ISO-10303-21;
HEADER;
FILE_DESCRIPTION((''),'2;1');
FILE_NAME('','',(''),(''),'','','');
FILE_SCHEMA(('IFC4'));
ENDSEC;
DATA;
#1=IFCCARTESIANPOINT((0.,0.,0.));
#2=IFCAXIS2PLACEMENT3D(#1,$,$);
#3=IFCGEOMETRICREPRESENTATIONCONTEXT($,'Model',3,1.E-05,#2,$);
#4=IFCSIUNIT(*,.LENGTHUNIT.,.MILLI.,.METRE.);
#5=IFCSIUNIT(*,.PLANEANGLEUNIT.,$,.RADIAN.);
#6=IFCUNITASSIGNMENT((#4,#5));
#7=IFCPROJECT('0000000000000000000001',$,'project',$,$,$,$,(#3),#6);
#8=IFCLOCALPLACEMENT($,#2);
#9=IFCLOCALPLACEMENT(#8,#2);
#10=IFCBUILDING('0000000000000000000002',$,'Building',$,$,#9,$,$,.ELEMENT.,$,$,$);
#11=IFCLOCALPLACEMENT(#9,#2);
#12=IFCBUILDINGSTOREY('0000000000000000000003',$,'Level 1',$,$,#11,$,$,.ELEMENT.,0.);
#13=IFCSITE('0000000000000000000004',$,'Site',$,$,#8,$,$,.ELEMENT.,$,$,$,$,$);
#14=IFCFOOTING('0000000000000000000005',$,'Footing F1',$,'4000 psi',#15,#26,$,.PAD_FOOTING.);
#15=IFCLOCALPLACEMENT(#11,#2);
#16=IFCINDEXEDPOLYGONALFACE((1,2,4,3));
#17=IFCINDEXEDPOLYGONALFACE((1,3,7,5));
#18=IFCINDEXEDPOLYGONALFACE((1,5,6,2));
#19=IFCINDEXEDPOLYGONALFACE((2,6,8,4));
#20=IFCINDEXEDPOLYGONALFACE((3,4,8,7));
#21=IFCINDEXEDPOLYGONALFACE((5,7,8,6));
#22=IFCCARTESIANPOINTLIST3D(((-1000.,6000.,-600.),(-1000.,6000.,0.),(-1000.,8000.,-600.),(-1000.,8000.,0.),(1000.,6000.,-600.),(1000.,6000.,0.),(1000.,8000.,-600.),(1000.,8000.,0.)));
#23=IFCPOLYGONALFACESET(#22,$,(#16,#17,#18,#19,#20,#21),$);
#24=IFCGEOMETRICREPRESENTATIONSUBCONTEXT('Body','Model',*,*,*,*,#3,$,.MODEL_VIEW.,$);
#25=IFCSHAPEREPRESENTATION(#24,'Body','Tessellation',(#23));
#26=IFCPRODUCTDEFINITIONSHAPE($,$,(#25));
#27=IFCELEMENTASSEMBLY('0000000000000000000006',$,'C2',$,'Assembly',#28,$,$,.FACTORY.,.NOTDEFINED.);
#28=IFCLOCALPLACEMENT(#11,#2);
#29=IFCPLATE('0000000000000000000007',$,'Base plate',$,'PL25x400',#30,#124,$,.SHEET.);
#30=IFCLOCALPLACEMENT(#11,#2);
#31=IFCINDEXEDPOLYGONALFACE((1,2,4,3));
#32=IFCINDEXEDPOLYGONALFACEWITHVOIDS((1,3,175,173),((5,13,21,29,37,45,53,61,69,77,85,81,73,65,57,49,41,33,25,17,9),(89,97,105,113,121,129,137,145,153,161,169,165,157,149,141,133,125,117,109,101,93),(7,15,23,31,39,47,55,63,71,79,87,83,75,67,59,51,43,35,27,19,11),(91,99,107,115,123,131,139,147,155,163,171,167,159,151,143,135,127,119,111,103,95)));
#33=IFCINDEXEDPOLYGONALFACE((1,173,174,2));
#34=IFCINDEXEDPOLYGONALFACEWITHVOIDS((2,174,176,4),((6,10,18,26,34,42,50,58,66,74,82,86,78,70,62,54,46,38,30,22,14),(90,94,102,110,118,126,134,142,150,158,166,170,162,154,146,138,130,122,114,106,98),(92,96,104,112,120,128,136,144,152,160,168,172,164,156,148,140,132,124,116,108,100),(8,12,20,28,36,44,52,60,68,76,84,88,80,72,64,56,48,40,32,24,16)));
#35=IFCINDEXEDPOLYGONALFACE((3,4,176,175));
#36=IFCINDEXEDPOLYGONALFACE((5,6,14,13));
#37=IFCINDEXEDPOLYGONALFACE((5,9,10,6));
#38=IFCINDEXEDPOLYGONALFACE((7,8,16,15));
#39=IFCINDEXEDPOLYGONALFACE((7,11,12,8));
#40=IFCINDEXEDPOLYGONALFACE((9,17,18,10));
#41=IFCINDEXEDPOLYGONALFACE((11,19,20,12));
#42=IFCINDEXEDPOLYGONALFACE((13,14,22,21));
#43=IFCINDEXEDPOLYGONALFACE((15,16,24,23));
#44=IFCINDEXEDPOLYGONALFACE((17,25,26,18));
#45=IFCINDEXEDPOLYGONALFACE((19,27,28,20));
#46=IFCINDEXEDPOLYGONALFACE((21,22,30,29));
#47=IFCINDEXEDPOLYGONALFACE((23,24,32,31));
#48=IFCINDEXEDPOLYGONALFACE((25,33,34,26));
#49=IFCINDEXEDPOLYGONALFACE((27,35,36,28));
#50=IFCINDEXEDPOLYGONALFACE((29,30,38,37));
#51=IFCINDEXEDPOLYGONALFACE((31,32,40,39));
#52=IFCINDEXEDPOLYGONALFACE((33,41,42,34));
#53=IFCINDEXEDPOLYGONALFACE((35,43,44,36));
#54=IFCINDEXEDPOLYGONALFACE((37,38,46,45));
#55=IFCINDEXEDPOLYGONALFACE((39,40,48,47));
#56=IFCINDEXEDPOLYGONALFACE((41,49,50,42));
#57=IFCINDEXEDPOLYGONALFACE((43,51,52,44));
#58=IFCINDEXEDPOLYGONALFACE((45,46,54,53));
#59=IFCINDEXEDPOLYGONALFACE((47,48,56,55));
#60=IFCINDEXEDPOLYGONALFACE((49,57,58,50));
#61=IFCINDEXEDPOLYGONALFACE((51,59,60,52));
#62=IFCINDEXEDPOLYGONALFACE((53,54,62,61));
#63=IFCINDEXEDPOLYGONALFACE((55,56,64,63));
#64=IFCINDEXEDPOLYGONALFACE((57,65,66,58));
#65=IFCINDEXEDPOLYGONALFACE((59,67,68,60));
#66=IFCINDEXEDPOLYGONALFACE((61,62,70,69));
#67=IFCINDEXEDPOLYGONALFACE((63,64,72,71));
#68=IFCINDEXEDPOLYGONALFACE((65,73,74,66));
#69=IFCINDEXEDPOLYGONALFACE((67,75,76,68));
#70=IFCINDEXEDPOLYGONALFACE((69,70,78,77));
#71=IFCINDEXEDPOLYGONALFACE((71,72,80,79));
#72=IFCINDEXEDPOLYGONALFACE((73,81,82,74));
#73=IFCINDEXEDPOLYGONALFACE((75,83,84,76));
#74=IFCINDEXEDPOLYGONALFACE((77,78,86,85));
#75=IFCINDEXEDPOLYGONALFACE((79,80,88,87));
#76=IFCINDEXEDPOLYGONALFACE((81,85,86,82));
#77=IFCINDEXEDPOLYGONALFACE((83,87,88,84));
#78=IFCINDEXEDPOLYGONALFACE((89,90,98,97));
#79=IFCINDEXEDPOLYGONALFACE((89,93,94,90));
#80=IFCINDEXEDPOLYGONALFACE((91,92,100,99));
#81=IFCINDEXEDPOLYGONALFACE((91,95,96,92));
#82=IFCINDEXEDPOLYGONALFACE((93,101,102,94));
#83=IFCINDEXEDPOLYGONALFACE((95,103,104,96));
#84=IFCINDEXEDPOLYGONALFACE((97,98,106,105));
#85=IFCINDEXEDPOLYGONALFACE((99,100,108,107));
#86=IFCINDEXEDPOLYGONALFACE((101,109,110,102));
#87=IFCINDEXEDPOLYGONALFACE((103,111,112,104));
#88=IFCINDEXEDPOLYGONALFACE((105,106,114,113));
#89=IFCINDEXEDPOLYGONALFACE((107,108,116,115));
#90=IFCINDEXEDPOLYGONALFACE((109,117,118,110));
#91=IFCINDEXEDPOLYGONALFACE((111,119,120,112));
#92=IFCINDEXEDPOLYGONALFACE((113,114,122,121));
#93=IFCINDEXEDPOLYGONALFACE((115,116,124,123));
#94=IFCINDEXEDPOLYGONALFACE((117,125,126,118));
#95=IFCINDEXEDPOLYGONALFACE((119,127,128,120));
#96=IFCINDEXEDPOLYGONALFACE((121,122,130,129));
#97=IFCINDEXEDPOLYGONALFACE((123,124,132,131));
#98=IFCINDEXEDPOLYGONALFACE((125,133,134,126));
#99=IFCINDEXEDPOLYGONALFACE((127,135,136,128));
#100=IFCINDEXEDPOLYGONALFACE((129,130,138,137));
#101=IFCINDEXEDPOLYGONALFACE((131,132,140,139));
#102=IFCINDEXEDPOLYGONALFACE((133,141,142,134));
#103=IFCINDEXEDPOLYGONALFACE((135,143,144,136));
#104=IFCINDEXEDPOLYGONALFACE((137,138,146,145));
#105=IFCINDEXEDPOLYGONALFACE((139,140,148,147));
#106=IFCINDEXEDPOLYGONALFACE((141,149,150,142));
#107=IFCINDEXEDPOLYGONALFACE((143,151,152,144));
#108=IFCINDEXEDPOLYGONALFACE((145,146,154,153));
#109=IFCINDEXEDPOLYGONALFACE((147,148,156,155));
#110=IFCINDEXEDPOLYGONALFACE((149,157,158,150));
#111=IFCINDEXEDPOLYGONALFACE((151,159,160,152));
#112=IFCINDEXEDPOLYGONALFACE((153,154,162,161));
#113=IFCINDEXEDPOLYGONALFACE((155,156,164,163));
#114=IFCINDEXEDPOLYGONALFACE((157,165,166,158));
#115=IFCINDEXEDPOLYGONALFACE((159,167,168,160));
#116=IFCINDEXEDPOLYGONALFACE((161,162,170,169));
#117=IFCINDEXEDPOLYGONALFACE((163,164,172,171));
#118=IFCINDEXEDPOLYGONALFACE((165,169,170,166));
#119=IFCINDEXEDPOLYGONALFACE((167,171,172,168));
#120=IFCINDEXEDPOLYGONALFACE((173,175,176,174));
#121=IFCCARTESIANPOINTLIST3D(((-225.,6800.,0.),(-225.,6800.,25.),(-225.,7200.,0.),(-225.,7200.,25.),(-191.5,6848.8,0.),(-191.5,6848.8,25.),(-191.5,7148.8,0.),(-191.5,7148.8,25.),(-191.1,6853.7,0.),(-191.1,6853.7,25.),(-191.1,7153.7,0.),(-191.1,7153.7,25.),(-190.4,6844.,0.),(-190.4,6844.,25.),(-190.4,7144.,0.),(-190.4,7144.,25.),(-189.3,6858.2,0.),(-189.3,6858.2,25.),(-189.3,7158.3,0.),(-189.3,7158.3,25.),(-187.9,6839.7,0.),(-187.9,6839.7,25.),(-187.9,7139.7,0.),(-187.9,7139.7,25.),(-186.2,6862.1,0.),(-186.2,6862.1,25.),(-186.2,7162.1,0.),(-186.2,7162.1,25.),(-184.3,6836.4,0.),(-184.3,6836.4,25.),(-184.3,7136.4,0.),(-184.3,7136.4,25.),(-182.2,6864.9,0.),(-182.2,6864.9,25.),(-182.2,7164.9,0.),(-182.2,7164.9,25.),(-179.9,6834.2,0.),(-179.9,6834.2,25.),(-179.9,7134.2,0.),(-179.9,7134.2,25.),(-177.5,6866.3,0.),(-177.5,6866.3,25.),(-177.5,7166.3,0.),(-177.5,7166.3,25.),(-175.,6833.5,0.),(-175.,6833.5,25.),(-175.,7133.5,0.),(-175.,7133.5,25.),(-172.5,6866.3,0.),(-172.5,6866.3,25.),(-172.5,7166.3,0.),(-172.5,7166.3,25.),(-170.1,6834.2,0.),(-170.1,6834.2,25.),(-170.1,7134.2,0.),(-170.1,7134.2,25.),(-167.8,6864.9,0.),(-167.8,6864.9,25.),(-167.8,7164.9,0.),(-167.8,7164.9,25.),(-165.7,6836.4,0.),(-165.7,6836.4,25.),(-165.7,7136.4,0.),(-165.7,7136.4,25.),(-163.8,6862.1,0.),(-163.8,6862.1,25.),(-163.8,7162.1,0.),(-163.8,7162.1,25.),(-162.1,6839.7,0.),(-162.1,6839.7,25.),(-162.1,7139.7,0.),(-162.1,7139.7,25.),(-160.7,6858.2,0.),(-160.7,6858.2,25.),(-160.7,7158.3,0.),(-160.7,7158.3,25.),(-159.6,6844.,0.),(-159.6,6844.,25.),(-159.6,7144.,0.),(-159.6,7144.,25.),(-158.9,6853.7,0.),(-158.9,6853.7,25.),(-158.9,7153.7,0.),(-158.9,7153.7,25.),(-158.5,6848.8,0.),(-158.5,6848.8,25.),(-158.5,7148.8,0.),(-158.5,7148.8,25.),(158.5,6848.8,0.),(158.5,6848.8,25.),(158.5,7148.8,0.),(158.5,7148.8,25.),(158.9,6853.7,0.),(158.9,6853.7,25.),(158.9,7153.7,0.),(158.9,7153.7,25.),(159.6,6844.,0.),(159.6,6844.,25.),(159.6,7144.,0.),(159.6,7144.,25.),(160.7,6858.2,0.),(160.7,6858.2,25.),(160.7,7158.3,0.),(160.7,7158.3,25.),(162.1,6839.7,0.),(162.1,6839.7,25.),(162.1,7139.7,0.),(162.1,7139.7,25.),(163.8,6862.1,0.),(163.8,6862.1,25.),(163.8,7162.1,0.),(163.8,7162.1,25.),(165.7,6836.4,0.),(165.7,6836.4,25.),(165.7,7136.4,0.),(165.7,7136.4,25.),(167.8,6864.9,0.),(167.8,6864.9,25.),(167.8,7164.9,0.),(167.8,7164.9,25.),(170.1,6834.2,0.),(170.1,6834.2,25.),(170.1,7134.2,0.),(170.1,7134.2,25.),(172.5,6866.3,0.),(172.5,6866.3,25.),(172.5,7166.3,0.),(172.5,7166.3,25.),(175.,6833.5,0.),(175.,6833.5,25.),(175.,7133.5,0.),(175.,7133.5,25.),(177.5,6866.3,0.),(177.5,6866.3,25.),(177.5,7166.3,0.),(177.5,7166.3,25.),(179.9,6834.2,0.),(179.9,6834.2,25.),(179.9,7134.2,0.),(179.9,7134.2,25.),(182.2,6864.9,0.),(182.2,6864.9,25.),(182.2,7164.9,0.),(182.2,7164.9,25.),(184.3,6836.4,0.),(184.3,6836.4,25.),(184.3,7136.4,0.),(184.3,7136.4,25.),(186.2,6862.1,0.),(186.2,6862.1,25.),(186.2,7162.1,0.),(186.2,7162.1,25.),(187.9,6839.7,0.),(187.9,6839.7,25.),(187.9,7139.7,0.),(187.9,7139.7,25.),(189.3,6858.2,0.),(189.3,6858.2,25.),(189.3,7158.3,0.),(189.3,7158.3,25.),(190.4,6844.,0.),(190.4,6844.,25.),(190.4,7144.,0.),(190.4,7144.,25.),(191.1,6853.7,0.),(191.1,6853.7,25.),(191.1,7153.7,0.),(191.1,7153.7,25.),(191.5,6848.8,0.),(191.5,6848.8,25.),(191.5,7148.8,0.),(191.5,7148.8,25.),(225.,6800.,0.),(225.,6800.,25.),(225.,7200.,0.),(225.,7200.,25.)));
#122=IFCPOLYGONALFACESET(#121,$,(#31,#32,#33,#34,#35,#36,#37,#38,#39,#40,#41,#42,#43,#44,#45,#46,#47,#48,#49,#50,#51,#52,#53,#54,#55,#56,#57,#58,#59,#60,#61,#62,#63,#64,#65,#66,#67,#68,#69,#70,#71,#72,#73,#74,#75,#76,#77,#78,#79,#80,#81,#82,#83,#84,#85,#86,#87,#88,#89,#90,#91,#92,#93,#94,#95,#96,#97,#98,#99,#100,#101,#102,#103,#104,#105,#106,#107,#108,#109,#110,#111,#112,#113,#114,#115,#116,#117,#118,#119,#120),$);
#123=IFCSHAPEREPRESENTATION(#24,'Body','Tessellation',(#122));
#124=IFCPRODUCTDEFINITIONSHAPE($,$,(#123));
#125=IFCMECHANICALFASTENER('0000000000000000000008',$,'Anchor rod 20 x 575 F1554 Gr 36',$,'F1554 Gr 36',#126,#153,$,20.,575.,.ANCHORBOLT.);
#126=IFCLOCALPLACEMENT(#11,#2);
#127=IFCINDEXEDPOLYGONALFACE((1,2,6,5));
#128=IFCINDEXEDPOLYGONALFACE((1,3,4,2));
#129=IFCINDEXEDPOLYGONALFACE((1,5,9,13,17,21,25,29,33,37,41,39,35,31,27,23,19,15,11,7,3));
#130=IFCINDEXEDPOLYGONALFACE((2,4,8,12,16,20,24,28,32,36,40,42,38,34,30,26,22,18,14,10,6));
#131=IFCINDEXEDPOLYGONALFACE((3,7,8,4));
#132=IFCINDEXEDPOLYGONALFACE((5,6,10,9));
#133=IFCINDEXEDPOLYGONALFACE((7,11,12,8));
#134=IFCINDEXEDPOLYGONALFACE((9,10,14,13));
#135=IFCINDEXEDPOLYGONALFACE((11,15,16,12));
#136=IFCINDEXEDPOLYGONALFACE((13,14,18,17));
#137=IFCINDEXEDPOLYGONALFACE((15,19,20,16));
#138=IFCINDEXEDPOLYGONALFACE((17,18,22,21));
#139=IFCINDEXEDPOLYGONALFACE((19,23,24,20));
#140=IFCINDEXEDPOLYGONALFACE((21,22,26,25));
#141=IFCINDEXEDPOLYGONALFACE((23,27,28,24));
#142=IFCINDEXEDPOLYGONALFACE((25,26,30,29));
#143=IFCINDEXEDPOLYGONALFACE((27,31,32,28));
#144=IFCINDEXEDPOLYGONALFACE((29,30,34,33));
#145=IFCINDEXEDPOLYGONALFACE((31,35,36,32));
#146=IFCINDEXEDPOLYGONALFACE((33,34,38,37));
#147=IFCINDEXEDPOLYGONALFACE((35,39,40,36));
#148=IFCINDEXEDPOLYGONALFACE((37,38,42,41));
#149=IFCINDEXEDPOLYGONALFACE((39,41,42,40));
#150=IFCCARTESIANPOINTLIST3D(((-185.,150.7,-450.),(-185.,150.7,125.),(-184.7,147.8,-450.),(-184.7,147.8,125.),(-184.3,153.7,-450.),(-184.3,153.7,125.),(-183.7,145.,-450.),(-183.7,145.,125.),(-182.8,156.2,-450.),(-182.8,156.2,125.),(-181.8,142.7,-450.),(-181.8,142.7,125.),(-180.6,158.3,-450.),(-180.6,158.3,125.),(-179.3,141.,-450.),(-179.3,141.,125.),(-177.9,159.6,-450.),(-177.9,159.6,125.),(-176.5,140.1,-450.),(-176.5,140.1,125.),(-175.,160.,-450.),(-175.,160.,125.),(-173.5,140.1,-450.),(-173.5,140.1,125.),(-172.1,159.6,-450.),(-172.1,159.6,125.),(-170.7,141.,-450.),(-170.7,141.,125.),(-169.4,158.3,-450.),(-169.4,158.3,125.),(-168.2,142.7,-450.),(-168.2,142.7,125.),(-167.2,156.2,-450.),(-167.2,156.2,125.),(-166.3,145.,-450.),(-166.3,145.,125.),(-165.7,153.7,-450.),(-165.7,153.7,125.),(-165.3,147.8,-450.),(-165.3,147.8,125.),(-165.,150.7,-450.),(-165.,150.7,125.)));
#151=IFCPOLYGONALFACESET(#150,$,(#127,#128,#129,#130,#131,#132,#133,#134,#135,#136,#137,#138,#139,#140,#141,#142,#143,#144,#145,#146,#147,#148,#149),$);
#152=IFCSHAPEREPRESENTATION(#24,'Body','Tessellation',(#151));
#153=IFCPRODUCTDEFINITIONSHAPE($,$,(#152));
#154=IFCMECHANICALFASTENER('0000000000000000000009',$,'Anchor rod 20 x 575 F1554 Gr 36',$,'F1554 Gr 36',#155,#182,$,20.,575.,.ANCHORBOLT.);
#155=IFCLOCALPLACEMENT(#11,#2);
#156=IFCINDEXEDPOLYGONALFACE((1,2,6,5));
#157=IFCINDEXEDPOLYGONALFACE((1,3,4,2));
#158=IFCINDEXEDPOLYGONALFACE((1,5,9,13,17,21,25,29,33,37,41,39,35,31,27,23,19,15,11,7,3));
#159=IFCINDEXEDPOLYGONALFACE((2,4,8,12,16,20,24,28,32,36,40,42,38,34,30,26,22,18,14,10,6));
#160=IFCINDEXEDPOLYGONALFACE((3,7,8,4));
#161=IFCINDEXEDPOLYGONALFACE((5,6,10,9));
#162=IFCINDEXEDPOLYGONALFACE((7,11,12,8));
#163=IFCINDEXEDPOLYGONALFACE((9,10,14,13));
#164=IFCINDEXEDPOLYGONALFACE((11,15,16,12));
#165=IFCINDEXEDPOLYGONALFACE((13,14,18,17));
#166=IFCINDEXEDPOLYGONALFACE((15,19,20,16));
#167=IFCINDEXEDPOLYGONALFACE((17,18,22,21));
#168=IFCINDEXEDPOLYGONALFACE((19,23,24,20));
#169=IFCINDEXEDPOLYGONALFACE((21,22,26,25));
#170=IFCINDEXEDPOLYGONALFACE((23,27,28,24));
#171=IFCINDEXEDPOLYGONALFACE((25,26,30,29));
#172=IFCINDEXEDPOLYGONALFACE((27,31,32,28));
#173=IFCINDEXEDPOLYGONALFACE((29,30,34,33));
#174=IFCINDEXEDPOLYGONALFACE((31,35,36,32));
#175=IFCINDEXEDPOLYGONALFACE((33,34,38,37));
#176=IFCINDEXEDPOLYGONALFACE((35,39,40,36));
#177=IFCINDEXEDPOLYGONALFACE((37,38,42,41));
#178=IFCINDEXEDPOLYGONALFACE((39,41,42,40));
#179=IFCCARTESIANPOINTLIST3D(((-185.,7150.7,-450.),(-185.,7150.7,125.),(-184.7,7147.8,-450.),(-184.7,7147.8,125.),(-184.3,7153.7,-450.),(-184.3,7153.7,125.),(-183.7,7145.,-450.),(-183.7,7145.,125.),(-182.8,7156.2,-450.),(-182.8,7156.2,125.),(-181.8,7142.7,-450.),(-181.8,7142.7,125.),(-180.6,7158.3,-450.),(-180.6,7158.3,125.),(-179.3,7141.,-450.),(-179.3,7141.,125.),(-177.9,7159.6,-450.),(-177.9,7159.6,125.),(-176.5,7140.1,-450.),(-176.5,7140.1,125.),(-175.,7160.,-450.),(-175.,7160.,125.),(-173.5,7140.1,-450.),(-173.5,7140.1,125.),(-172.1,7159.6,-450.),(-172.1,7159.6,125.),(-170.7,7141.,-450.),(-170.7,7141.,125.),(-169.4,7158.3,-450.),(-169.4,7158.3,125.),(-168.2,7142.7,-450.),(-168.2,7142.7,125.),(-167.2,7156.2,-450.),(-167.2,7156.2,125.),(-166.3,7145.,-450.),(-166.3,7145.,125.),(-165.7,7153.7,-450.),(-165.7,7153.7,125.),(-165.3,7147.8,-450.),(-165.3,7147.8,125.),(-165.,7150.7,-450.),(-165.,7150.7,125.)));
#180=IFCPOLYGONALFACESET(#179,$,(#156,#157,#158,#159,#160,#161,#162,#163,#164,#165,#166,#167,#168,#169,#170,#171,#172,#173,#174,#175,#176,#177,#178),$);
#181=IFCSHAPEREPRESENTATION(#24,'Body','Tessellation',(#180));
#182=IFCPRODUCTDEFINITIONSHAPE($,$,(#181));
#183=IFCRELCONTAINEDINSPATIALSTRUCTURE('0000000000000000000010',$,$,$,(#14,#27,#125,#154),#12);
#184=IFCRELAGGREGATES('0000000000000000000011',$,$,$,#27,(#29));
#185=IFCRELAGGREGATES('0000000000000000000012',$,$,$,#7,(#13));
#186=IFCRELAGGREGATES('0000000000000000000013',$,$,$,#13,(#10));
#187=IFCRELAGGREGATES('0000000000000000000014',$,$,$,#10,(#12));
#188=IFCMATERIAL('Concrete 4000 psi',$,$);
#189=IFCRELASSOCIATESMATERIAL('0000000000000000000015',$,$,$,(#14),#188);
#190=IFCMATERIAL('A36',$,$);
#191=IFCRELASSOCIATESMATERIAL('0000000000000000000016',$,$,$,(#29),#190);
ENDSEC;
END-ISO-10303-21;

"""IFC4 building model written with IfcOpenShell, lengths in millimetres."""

from ifc_helpers import new_model, si_unit, frame, origin, origin_2d, place, context, subcontext, project, spatial, rectangle, circle, extrude, material, element, aggregate, save


model = new_model("IFC4")

# Units and contexts
model_context = context("Model", 3, precision=1e-05, world=origin())
body_context = subcontext(model_context, "Body", "Model", "MODEL_VIEW")
ifc_project = project(units=[si_unit("LENGTHUNIT", "METRE", prefix="MILLI"), si_unit("PLANEANGLEUNIT", "RADIAN")], contexts=[model_context])

# Site, building, storey
site_placement = place(None, origin())
site = spatial("IfcSite", under=ifc_project, at=site_placement, Name="Site", CompositionType="ELEMENT")
building_placement = place(site_placement, origin())
building = spatial("IfcBuilding", under=site, at=building_placement, Name="Building", CompositionType="ELEMENT")
storey_placement = place(building_placement, origin())
storey = spatial("IfcBuildingStorey", under=building, at=storey_placement, Name="Level 1", CompositionType="ELEMENT", Elevation=0.0)

# Footing
ifc_material_1 = material(Name="Concrete 4000 psi")
footing_placement = place(storey_placement, frame((0.0, 7000.0, -600.0), z_axis=(0.0, 0.0, 1.0), x_axis=(1.0, 0.0, 0.0)))
element("IfcFooting", 1, at=footing_placement, inside=storey, material=ifc_material_1, Name="Footing F1", ObjectType="4000 psi", PredefinedType="PAD_FOOTING", context=body_context, shape_type="SweptSolid", body=[
    extrude(rectangle(XDim=2000.0, YDim=2000.0, at=origin_2d()), origin(), (0.0, 0.0, 1.0), 600.0),
])

# Element assembly, plate, openings
assembly_placement = place(storey_placement, origin())
assembly = element("IfcElementAssembly", 2, at=assembly_placement, inside=storey, Name="C2", ObjectType="Assembly", AssemblyPlace="FACTORY", PredefinedType="NOTDEFINED")
ifc_material_2 = material(Name="A36")
plate_placement = place(storey_placement, frame((-225.0, 7000.0, 12.5), z_axis=(1.0, 0.0, 0.0), x_axis=(0.0, 1.0, 0.0)))
plate = element("IfcPlate", 3, at=plate_placement, material=ifc_material_2, Name="Base plate", ObjectType="PL25x400", PredefinedType="SHEET", context=body_context, shape_type="SweptSolid", body=[
    extrude(rectangle(XDim=400.0, YDim=25.0, at=origin_2d()), origin(), (0.0, 0.0, 1.0), 450.0),
])
opening_1_placement = place(plate_placement, frame((-150.0, -13.5, 50.0), z_axis=(0.0, 1.0, 0.0), x_axis=(-1.0, 0.0, 0.0)))
element("IfcOpeningElement", 4, at=opening_1_placement, cuts=plate, PredefinedType="OPENING", context=body_context, shape_type="SweptSolid", body=[
    extrude(circle(Radius=16.5, at=origin_2d()), origin(), (0.0, 0.0, 1.0), 27.0),
])
opening_2_placement = place(plate_placement, frame((150.0, -13.5, 50.0), z_axis=(0.0, 1.0, 0.0), x_axis=(-1.0, 0.0, 0.0)))
element("IfcOpeningElement", 5, at=opening_2_placement, cuts=plate, PredefinedType="OPENING", context=body_context, shape_type="SweptSolid", body=[
    extrude(circle(Radius=16.5, at=origin_2d()), origin(), (0.0, 0.0, 1.0), 27.0),
])
opening_3_placement = place(plate_placement, frame((-150.0, -13.5, 400.0), z_axis=(0.0, 1.0, 0.0), x_axis=(-1.0, 0.0, 0.0)))
element("IfcOpeningElement", 6, at=opening_3_placement, cuts=plate, PredefinedType="OPENING", context=body_context, shape_type="SweptSolid", body=[
    extrude(circle(Radius=16.5, at=origin_2d()), origin(), (0.0, 0.0, 1.0), 27.0),
])
opening_4_placement = place(plate_placement, frame((150.0, -13.5, 400.0), z_axis=(0.0, 1.0, 0.0), x_axis=(-1.0, 0.0, 0.0)))
element("IfcOpeningElement", 7, at=opening_4_placement, cuts=plate, PredefinedType="OPENING", context=body_context, shape_type="SweptSolid", body=[
    extrude(circle(Radius=16.5, at=origin_2d()), origin(), (0.0, 0.0, 1.0), 27.0),
])
aggregate(assembly, [plate])

# Mechanical fasteners
for number, where, z_axis, x_axis, name in (
    (8, (-175.0, 150.0, 125.0), (0.0, 0.0, -1.0), (0.0, 1.0, 0.0), "Anchor rod 20 x 575 F1554 Gr 36"),
    (9, (-175.0, 7150.0, 125.0), (0.0, 0.0, -1.0), (0.0, 1.0, 0.0), "Anchor rod 20 x 575 F1554 Gr 36"),
):
    element("IfcMechanicalFastener", number, at=place(storey_placement, frame(where, z_axis=z_axis, x_axis=x_axis)), inside=storey, Name=name, ObjectType="F1554 Gr 36", NominalDiameter=20.0, NominalLength=575.0, PredefinedType="ANCHORBOLT", context=body_context, shape_type="SweptSolid", body=[
        extrude(circle(Radius=10.0, at=origin_2d()), origin(), (0.0, 0.0, 1.0), 575.0),
    ])

save(model, "model.ifc")
